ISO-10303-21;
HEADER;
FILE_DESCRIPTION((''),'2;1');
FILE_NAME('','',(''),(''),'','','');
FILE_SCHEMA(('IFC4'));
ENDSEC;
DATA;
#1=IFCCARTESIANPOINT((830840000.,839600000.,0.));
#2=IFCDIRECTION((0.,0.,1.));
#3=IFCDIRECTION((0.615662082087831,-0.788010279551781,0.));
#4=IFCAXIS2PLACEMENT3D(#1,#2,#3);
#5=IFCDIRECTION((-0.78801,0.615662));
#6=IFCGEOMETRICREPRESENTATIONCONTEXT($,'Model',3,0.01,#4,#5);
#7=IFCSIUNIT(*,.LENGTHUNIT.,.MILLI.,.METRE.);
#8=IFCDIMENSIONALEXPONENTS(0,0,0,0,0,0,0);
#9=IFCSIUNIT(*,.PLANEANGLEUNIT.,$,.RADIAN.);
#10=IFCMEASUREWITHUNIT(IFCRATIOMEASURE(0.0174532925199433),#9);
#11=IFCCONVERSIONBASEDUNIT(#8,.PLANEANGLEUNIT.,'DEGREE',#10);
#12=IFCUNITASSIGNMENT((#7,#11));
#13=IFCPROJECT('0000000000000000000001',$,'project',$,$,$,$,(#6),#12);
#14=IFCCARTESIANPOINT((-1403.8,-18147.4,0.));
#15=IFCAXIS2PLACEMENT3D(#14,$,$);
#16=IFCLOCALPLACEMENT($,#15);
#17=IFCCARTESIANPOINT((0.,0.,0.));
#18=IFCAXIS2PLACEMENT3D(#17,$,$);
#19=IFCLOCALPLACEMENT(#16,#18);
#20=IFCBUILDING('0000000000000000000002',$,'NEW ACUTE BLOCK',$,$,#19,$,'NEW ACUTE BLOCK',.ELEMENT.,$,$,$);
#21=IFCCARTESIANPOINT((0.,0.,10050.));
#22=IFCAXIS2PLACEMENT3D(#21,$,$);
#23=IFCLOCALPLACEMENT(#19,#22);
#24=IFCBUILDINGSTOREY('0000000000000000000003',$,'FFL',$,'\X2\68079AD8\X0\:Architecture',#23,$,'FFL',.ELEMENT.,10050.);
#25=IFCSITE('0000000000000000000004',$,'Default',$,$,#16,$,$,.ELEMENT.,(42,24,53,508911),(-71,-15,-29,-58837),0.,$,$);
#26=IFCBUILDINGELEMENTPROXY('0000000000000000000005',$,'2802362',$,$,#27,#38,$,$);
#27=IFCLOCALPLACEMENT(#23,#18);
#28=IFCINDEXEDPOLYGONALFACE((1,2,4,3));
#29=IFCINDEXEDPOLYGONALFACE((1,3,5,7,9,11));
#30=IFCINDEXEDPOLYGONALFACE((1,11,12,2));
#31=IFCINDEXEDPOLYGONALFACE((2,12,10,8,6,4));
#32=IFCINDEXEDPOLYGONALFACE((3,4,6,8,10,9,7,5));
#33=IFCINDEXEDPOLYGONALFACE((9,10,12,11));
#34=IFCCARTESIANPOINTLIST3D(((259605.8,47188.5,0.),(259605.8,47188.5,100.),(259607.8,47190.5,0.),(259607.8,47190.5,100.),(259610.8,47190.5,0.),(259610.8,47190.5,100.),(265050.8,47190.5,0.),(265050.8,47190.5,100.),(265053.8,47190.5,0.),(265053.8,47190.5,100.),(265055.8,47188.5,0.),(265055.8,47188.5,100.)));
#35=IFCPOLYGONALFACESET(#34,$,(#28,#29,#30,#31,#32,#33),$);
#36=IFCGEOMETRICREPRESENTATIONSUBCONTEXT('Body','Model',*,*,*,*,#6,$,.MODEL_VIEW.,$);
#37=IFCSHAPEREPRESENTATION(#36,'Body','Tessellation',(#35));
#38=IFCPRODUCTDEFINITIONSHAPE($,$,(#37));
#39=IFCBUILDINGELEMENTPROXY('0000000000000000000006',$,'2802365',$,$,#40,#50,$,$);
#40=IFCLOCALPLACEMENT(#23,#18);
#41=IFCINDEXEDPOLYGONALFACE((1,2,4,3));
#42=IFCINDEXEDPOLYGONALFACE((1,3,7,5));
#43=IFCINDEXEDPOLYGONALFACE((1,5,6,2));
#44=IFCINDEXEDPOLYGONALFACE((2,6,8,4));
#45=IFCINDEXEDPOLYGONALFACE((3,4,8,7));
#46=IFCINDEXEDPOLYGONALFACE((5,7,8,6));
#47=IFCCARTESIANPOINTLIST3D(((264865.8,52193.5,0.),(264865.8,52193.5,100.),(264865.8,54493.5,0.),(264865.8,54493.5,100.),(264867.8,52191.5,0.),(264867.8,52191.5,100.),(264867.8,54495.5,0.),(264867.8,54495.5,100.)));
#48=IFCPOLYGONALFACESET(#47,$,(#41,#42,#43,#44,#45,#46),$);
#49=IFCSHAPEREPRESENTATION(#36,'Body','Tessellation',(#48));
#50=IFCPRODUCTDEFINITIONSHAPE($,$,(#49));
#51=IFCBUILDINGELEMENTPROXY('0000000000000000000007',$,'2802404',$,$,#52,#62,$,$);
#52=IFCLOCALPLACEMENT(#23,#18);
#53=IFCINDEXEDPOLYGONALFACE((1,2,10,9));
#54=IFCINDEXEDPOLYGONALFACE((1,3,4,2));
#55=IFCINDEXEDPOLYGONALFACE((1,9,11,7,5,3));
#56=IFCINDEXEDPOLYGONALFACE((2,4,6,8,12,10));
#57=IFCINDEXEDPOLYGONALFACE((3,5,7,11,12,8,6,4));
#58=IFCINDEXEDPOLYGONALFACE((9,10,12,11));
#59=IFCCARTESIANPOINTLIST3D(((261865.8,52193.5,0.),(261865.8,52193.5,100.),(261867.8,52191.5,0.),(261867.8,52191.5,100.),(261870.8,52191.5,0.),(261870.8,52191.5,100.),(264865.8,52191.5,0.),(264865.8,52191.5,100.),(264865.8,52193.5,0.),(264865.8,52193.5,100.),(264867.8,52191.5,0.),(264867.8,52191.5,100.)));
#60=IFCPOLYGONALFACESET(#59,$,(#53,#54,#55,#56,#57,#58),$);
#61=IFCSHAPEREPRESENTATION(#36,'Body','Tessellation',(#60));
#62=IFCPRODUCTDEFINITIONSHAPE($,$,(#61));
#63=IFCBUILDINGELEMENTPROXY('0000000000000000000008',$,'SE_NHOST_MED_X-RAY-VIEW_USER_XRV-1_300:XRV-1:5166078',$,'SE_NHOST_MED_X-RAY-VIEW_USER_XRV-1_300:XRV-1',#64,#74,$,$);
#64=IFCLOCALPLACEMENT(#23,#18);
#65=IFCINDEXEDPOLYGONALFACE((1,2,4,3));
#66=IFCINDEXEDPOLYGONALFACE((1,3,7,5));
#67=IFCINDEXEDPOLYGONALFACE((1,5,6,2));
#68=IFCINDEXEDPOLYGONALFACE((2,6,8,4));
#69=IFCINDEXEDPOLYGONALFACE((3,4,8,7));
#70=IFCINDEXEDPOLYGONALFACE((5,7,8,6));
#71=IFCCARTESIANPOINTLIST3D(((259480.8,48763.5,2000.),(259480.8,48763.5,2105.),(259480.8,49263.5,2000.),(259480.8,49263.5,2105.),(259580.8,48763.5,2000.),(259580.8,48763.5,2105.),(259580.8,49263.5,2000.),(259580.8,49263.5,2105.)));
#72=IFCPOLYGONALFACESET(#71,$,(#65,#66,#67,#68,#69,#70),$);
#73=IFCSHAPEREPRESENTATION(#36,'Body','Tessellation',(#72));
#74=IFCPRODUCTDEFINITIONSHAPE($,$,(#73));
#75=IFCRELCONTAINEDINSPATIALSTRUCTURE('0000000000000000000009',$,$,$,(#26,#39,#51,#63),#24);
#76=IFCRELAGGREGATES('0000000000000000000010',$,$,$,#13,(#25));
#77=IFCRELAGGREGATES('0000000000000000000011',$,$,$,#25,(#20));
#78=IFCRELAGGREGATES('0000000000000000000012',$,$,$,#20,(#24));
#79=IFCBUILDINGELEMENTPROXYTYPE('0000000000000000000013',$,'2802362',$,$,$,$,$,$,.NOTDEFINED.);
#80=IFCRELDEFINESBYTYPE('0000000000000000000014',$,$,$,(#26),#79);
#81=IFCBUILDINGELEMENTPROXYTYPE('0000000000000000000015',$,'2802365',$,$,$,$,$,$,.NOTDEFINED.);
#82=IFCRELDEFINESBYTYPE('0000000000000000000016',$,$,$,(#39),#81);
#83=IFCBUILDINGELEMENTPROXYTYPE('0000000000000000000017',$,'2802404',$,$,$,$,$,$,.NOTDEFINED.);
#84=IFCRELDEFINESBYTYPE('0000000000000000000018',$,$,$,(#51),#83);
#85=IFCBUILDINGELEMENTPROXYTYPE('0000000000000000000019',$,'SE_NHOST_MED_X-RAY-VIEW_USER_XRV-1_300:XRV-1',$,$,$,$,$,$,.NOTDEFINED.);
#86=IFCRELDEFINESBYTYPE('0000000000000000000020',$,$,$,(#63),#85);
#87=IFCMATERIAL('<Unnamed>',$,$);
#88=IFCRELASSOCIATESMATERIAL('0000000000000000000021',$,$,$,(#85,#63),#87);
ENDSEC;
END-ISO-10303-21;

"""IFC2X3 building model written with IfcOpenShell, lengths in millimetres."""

from ifc_helpers import new_model, entity, si_unit, converted_unit, direction, frame, origin, origin_2d_with_axis, place, context, subcontext, project, spatial, polyline, rectangle, outline, extrude, source, transform, mapped, material, type_object, type_shapes, element, save


model = new_model("IFC2X3")

# Units and contexts
model_context = context("Model", 3, precision=0.01, world=frame((830840000.0, 839600000.0, 0.0), z_axis=(0.0, 0.0, 1.0), x_axis=(0.615662082087831, -0.788010279551781, 0.0)), true_north=direction((-0.78801, 0.615662)))
body_context = subcontext(model_context, "Body", "Model", "MODEL_VIEW")
ifc_project = project(units=[si_unit("LENGTHUNIT", "METRE", prefix="MILLI"), converted_unit("PLANEANGLEUNIT", "DEGREE", entity("IfcRatioMeasure", 0.0174532925199433), si_unit("PLANEANGLEUNIT", "RADIAN"), dimensions=[0, 0, 0, 0, 0, 0, 0])], contexts=[model_context])

# Site, building, storey
site_placement = place(None, frame((-1403.8, -18147.4, 0.0)))
site = spatial("IfcSite", under=ifc_project, at=site_placement, Name="Default", CompositionType="ELEMENT", RefLatitude=(42, 24, 53, 508911), RefLongitude=(-71, -15, -29, -58837), RefElevation=0.0)
building_placement = place(site_placement, origin())
building = spatial("IfcBuilding", under=site, at=building_placement, Name="NEW ACUTE BLOCK", LongName="NEW ACUTE BLOCK", CompositionType="ELEMENT")
storey_placement = place(building_placement, frame((0.0, 0.0, 10050.0)))
storey = spatial("IfcBuildingStorey", under=building, at=storey_placement, Name="FFL", ObjectType="标高:Architecture", LongName="FFL", CompositionType="ELEMENT", Elevation=10050.0)

# Building element proxies
ifc_material = material(Name="<Unnamed>")
building_element_proxy_type_1 = type_object("IfcBuildingElementProxyType", Name="2802362", PredefinedType="NOTDEFINED")
proxy_1_placement = place(storey_placement, frame((259605.8, 47188.5, 0.0)))
element("IfcBuildingElementProxy", 1, at=proxy_1_placement, inside=storey, type_object=building_element_proxy_type_1, Name="2802362", context=body_context, shape_type="SweptSolid", body=[
    extrude(outline(polyline([(-2725.0, -1.3), (2725.0, -1.3), (2723.0, 0.7), (2720.0, 0.7), (-2720.0, 0.7), (-2723.0, 0.7), (-2725.0, -1.3)])), frame((2725.0, 1.3, 0.0)), (0.0, 0.0, 1.0), 100.0),
])
building_element_proxy_type_2 = type_object("IfcBuildingElementProxyType", Name="2802365", PredefinedType="NOTDEFINED")
proxy_2_placement = place(storey_placement, frame((264865.8, 52191.5, 0.0)))
element("IfcBuildingElementProxy", 2, at=proxy_2_placement, inside=storey, type_object=building_element_proxy_type_2, Name="2802365", context=body_context, shape_type="SweptSolid", body=[
    extrude(outline(polyline([(-1150.0, -1.0), (1150.0, -1.0), (1152.0, 1.0), (-1152.0, 1.0), (-1150.0, -1.0)])), frame((1.0, 1152.0, 0.0), z_axis=(0.0, 0.0, 1.0), x_axis=(0.0, -1.0, 0.0)), (0.0, 0.0, 1.0), 100.0),
])
building_element_proxy_type_3 = type_object("IfcBuildingElementProxyType", Name="2802404", PredefinedType="NOTDEFINED")
proxy_3_placement = place(storey_placement, frame((261865.8, 52191.5, 0.0)))
element("IfcBuildingElementProxy", 3, at=proxy_3_placement, inside=storey, type_object=building_element_proxy_type_3, Name="2802404", context=body_context, shape_type="SweptSolid", body=[
    extrude(outline(polyline([(-1498.5, -1.3), (1501.5, -1.3), (1499.5, 0.7), (1496.5, 0.7), (-1498.5, 0.7), (-1500.5, 0.7), (-1498.5, -1.3)])), frame((1501.5, 0.7, 0.0), z_axis=(0.0, 0.0, 1.0), x_axis=(-1.0, 0.0, 0.0)), (0.0, 0.0, 1.0), 100.0),
])
building_element_proxy_type_4 = type_object("IfcBuildingElementProxyType", Name="SE_NHOST_MED_X-RAY-VIEW_USER_XRV-1_300:XRV-1", PredefinedType="NOTDEFINED", material=ifc_material)
shared_shape_1 = source(origin(), body_context, "Body", "SweptSolid", [
    extrude(rectangle(XDim=500.0, YDim=100.0, at=origin_2d_with_axis()), frame((0.0, 0.0, 0.0), z_axis=(0.0, 0.0, 1.0), x_axis=(-1.0, 0.0, 0.0)), (0.0, 0.0, 1.0), 105.0),
])
type_shapes(building_element_proxy_type_4, [shared_shape_1])
proxy_4_placement = place(storey_placement, frame((259530.8, 49013.5, 2000.0), z_axis=(0.0, 0.0, 1.0), x_axis=(0.0, 1.0, 0.0)))
element("IfcBuildingElementProxy", 4, at=proxy_4_placement, inside=storey, type_object=building_element_proxy_type_4, material=ifc_material, Name="SE_NHOST_MED_X-RAY-VIEW_USER_XRV-1_300:XRV-1:5166078", ObjectType="SE_NHOST_MED_X-RAY-VIEW_USER_XRV-1_300:XRV-1", context=body_context, shape_type="MappedRepresentation", body=[
    mapped(shared_shape_1, transform((0.0, 0.0, 0.0), scale=1.0)),
])

save(model, "model.ifc")
